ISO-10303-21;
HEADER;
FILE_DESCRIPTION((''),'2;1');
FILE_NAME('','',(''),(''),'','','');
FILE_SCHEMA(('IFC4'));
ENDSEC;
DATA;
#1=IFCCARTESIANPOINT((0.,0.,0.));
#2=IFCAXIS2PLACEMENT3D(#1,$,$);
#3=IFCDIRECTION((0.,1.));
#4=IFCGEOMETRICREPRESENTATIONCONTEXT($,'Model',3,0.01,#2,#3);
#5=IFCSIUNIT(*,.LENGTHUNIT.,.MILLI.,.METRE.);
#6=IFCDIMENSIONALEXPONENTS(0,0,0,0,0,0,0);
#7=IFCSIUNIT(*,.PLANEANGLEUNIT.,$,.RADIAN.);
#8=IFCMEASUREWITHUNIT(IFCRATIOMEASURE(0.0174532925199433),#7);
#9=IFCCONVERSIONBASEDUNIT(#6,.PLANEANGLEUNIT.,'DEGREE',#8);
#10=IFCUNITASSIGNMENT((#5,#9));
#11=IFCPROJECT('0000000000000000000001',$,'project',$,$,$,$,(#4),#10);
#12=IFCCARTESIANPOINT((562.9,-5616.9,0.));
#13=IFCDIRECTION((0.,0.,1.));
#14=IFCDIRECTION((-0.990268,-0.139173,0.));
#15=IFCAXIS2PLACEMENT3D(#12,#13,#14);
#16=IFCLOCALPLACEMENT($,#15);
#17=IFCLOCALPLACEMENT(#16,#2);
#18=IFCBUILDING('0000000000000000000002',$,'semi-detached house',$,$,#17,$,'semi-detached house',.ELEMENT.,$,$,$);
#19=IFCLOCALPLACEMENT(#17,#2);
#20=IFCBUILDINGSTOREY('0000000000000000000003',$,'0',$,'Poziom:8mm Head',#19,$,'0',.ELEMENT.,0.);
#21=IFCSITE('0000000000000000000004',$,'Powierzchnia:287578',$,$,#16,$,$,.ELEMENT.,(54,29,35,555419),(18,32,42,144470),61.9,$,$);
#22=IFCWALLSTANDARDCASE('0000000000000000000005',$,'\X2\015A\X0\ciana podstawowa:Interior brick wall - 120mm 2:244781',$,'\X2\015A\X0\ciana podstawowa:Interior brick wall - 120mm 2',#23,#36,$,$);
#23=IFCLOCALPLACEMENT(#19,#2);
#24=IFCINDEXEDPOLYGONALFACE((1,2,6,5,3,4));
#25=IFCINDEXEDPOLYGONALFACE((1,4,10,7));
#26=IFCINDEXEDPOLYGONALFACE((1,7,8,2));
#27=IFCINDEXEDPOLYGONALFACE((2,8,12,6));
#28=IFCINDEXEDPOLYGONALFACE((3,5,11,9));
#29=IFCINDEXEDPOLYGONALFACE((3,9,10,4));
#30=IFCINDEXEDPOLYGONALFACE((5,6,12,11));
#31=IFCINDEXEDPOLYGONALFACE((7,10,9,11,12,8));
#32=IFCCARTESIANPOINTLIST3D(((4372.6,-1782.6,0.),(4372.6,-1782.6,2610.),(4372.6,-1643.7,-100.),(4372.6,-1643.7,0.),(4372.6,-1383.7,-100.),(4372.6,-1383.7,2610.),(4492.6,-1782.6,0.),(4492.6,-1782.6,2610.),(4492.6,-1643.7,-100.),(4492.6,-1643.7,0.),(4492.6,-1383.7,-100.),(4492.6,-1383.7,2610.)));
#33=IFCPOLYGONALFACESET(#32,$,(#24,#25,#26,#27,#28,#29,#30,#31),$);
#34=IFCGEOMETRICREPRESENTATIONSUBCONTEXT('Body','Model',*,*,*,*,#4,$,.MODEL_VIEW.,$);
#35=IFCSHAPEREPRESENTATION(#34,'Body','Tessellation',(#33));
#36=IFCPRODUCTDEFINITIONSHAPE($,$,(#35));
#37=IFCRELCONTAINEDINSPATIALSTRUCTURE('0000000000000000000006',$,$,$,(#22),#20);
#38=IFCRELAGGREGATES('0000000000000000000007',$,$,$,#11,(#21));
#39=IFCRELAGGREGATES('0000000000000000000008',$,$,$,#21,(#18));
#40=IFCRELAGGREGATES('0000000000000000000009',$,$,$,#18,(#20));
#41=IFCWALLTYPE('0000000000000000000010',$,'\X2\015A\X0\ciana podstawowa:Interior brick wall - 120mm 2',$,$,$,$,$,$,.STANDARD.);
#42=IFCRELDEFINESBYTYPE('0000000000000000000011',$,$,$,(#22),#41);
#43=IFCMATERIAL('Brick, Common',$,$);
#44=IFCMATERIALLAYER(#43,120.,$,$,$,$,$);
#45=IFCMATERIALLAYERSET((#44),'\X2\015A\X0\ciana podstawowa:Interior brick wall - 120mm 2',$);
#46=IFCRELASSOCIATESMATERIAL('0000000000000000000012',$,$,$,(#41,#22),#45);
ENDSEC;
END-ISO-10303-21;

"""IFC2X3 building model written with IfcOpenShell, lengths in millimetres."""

from ifc_helpers import new_model, entity, si_unit, converted_unit, direction, frame, frame_2d, origin, place, context, subcontext, project, spatial, polyline, rectangle, extrude, clip, bounded_halfspace, material, layer, layer_set, layer_usage, type_object, element, save


model = new_model("IFC2X3")

# Units and contexts
model_context = context("Model", 3, precision=0.01, world=origin(), true_north=direction((0.0, 1.0)))
body_context = subcontext(model_context, "Body", "Model", "MODEL_VIEW")
ifc_project = project(units=[si_unit("LENGTHUNIT", "METRE", prefix="MILLI"), converted_unit("PLANEANGLEUNIT", "DEGREE", entity("IfcRatioMeasure", 0.0174532925199433), si_unit("PLANEANGLEUNIT", "RADIAN"), dimensions=[0, 0, 0, 0, 0, 0, 0])], contexts=[model_context])

# Site, building, storey
site_placement = place(None, frame((562.9, -5616.9, 0.0), z_axis=(0.0, 0.0, 1.0), x_axis=(-0.990268, -0.139173, 0.0)))
site = spatial("IfcSite", under=ifc_project, at=site_placement, Name="Powierzchnia:287578", CompositionType="ELEMENT", RefLatitude=(54, 29, 35, 555419), RefLongitude=(18, 32, 42, 144470), RefElevation=61.9)
building_placement = place(site_placement, origin())
building = spatial("IfcBuilding", under=site, at=building_placement, Name="semi-detached house", LongName="semi-detached house", CompositionType="ELEMENT")
storey_placement = place(building_placement, origin())
storey = spatial("IfcBuildingStorey", under=building, at=storey_placement, Name="0", ObjectType="Poziom:8mm Head", LongName="0", CompositionType="ELEMENT", Elevation=0.0)

# Shared definitions
ifc_material_1 = material(Name="Brick, Common")

# Wall
ifc_layer_1 = layer(ifc_material_1, 120.0)
ifc_layer_set_1 = layer_set([ifc_layer_1], Name="Ściana podstawowa:Interior brick wall - 120mm 2")
wall_type_1 = type_object("IfcWallType", Name="Ściana podstawowa:Interior brick wall - 120mm 2", PredefinedType="STANDARD", material=ifc_layer_set_1)
ifc_layer_usage_1 = layer_usage(ifc_layer_set_1, "AXIS2", "POSITIVE", -60.0)
wall_1_placement = place(storey_placement, frame((4432.6, -1383.7, -100.0), z_axis=(0.0, 0.0, 1.0), x_axis=(0.0, -1.0, 0.0)))
element("IfcWallStandardCase", 1, at=wall_1_placement, inside=storey, type_object=wall_type_1, material=ifc_layer_usage_1, Name="Ściana podstawowa:Interior brick wall - 120mm 2:244781", ObjectType="Ściana podstawowa:Interior brick wall - 120mm 2", context=body_context, shape_type="Clipping", body=[
    clip(clip(clip(extrude(rectangle(XDim=398.9, YDim=120.0, at=frame_2d((199.5, 0.0), x_axis=(-1.0, 0.0))), origin(), (0.0, 0.0, 1.0), 2710.0), bounded_halfspace(frame((0.0, -60.0, 2710.0), z_axis=(0.0, 0.0, -1.0), x_axis=(0.0, 1.0, 0.0)), True, frame((0.0, -60.0, 2710.0)), polyline([(0.0, 0.0), (138.9, 0.0), (140.0, 0.0), (260.0, 0.0), (398.9, 0.0), (398.9, 120.0), (260.0, 120.0), (140.0, 120.0), (138.9, 120.0), (0.0, 120.0), (0.0, 0.0)]))), bounded_halfspace(frame((260.0, -60.0, 100.0)), True, frame((260.0, -60.0, 100.0)), polyline([(0.0, 0.0), (138.9, 0.0), (138.9, 120.0), (0.0, 120.0), (0.0, 0.0)]))), bounded_halfspace(frame((260.0, 60.0, 100.0), z_axis=(-1.0, 0.0, 0.0), x_axis=(0.0, 0.0, 1.0)), True, frame((260.0, 60.0, 100.0), z_axis=(-1.0, 0.0, 0.0), x_axis=(0.0, 0.0, 1.0)), polyline([(0.0, 0.0), (-100.0, 0.0), (-100.0, -120.0), (0.0, -120.0), (0.0, 0.0)]))),
])

save(model, "model.ifc")
